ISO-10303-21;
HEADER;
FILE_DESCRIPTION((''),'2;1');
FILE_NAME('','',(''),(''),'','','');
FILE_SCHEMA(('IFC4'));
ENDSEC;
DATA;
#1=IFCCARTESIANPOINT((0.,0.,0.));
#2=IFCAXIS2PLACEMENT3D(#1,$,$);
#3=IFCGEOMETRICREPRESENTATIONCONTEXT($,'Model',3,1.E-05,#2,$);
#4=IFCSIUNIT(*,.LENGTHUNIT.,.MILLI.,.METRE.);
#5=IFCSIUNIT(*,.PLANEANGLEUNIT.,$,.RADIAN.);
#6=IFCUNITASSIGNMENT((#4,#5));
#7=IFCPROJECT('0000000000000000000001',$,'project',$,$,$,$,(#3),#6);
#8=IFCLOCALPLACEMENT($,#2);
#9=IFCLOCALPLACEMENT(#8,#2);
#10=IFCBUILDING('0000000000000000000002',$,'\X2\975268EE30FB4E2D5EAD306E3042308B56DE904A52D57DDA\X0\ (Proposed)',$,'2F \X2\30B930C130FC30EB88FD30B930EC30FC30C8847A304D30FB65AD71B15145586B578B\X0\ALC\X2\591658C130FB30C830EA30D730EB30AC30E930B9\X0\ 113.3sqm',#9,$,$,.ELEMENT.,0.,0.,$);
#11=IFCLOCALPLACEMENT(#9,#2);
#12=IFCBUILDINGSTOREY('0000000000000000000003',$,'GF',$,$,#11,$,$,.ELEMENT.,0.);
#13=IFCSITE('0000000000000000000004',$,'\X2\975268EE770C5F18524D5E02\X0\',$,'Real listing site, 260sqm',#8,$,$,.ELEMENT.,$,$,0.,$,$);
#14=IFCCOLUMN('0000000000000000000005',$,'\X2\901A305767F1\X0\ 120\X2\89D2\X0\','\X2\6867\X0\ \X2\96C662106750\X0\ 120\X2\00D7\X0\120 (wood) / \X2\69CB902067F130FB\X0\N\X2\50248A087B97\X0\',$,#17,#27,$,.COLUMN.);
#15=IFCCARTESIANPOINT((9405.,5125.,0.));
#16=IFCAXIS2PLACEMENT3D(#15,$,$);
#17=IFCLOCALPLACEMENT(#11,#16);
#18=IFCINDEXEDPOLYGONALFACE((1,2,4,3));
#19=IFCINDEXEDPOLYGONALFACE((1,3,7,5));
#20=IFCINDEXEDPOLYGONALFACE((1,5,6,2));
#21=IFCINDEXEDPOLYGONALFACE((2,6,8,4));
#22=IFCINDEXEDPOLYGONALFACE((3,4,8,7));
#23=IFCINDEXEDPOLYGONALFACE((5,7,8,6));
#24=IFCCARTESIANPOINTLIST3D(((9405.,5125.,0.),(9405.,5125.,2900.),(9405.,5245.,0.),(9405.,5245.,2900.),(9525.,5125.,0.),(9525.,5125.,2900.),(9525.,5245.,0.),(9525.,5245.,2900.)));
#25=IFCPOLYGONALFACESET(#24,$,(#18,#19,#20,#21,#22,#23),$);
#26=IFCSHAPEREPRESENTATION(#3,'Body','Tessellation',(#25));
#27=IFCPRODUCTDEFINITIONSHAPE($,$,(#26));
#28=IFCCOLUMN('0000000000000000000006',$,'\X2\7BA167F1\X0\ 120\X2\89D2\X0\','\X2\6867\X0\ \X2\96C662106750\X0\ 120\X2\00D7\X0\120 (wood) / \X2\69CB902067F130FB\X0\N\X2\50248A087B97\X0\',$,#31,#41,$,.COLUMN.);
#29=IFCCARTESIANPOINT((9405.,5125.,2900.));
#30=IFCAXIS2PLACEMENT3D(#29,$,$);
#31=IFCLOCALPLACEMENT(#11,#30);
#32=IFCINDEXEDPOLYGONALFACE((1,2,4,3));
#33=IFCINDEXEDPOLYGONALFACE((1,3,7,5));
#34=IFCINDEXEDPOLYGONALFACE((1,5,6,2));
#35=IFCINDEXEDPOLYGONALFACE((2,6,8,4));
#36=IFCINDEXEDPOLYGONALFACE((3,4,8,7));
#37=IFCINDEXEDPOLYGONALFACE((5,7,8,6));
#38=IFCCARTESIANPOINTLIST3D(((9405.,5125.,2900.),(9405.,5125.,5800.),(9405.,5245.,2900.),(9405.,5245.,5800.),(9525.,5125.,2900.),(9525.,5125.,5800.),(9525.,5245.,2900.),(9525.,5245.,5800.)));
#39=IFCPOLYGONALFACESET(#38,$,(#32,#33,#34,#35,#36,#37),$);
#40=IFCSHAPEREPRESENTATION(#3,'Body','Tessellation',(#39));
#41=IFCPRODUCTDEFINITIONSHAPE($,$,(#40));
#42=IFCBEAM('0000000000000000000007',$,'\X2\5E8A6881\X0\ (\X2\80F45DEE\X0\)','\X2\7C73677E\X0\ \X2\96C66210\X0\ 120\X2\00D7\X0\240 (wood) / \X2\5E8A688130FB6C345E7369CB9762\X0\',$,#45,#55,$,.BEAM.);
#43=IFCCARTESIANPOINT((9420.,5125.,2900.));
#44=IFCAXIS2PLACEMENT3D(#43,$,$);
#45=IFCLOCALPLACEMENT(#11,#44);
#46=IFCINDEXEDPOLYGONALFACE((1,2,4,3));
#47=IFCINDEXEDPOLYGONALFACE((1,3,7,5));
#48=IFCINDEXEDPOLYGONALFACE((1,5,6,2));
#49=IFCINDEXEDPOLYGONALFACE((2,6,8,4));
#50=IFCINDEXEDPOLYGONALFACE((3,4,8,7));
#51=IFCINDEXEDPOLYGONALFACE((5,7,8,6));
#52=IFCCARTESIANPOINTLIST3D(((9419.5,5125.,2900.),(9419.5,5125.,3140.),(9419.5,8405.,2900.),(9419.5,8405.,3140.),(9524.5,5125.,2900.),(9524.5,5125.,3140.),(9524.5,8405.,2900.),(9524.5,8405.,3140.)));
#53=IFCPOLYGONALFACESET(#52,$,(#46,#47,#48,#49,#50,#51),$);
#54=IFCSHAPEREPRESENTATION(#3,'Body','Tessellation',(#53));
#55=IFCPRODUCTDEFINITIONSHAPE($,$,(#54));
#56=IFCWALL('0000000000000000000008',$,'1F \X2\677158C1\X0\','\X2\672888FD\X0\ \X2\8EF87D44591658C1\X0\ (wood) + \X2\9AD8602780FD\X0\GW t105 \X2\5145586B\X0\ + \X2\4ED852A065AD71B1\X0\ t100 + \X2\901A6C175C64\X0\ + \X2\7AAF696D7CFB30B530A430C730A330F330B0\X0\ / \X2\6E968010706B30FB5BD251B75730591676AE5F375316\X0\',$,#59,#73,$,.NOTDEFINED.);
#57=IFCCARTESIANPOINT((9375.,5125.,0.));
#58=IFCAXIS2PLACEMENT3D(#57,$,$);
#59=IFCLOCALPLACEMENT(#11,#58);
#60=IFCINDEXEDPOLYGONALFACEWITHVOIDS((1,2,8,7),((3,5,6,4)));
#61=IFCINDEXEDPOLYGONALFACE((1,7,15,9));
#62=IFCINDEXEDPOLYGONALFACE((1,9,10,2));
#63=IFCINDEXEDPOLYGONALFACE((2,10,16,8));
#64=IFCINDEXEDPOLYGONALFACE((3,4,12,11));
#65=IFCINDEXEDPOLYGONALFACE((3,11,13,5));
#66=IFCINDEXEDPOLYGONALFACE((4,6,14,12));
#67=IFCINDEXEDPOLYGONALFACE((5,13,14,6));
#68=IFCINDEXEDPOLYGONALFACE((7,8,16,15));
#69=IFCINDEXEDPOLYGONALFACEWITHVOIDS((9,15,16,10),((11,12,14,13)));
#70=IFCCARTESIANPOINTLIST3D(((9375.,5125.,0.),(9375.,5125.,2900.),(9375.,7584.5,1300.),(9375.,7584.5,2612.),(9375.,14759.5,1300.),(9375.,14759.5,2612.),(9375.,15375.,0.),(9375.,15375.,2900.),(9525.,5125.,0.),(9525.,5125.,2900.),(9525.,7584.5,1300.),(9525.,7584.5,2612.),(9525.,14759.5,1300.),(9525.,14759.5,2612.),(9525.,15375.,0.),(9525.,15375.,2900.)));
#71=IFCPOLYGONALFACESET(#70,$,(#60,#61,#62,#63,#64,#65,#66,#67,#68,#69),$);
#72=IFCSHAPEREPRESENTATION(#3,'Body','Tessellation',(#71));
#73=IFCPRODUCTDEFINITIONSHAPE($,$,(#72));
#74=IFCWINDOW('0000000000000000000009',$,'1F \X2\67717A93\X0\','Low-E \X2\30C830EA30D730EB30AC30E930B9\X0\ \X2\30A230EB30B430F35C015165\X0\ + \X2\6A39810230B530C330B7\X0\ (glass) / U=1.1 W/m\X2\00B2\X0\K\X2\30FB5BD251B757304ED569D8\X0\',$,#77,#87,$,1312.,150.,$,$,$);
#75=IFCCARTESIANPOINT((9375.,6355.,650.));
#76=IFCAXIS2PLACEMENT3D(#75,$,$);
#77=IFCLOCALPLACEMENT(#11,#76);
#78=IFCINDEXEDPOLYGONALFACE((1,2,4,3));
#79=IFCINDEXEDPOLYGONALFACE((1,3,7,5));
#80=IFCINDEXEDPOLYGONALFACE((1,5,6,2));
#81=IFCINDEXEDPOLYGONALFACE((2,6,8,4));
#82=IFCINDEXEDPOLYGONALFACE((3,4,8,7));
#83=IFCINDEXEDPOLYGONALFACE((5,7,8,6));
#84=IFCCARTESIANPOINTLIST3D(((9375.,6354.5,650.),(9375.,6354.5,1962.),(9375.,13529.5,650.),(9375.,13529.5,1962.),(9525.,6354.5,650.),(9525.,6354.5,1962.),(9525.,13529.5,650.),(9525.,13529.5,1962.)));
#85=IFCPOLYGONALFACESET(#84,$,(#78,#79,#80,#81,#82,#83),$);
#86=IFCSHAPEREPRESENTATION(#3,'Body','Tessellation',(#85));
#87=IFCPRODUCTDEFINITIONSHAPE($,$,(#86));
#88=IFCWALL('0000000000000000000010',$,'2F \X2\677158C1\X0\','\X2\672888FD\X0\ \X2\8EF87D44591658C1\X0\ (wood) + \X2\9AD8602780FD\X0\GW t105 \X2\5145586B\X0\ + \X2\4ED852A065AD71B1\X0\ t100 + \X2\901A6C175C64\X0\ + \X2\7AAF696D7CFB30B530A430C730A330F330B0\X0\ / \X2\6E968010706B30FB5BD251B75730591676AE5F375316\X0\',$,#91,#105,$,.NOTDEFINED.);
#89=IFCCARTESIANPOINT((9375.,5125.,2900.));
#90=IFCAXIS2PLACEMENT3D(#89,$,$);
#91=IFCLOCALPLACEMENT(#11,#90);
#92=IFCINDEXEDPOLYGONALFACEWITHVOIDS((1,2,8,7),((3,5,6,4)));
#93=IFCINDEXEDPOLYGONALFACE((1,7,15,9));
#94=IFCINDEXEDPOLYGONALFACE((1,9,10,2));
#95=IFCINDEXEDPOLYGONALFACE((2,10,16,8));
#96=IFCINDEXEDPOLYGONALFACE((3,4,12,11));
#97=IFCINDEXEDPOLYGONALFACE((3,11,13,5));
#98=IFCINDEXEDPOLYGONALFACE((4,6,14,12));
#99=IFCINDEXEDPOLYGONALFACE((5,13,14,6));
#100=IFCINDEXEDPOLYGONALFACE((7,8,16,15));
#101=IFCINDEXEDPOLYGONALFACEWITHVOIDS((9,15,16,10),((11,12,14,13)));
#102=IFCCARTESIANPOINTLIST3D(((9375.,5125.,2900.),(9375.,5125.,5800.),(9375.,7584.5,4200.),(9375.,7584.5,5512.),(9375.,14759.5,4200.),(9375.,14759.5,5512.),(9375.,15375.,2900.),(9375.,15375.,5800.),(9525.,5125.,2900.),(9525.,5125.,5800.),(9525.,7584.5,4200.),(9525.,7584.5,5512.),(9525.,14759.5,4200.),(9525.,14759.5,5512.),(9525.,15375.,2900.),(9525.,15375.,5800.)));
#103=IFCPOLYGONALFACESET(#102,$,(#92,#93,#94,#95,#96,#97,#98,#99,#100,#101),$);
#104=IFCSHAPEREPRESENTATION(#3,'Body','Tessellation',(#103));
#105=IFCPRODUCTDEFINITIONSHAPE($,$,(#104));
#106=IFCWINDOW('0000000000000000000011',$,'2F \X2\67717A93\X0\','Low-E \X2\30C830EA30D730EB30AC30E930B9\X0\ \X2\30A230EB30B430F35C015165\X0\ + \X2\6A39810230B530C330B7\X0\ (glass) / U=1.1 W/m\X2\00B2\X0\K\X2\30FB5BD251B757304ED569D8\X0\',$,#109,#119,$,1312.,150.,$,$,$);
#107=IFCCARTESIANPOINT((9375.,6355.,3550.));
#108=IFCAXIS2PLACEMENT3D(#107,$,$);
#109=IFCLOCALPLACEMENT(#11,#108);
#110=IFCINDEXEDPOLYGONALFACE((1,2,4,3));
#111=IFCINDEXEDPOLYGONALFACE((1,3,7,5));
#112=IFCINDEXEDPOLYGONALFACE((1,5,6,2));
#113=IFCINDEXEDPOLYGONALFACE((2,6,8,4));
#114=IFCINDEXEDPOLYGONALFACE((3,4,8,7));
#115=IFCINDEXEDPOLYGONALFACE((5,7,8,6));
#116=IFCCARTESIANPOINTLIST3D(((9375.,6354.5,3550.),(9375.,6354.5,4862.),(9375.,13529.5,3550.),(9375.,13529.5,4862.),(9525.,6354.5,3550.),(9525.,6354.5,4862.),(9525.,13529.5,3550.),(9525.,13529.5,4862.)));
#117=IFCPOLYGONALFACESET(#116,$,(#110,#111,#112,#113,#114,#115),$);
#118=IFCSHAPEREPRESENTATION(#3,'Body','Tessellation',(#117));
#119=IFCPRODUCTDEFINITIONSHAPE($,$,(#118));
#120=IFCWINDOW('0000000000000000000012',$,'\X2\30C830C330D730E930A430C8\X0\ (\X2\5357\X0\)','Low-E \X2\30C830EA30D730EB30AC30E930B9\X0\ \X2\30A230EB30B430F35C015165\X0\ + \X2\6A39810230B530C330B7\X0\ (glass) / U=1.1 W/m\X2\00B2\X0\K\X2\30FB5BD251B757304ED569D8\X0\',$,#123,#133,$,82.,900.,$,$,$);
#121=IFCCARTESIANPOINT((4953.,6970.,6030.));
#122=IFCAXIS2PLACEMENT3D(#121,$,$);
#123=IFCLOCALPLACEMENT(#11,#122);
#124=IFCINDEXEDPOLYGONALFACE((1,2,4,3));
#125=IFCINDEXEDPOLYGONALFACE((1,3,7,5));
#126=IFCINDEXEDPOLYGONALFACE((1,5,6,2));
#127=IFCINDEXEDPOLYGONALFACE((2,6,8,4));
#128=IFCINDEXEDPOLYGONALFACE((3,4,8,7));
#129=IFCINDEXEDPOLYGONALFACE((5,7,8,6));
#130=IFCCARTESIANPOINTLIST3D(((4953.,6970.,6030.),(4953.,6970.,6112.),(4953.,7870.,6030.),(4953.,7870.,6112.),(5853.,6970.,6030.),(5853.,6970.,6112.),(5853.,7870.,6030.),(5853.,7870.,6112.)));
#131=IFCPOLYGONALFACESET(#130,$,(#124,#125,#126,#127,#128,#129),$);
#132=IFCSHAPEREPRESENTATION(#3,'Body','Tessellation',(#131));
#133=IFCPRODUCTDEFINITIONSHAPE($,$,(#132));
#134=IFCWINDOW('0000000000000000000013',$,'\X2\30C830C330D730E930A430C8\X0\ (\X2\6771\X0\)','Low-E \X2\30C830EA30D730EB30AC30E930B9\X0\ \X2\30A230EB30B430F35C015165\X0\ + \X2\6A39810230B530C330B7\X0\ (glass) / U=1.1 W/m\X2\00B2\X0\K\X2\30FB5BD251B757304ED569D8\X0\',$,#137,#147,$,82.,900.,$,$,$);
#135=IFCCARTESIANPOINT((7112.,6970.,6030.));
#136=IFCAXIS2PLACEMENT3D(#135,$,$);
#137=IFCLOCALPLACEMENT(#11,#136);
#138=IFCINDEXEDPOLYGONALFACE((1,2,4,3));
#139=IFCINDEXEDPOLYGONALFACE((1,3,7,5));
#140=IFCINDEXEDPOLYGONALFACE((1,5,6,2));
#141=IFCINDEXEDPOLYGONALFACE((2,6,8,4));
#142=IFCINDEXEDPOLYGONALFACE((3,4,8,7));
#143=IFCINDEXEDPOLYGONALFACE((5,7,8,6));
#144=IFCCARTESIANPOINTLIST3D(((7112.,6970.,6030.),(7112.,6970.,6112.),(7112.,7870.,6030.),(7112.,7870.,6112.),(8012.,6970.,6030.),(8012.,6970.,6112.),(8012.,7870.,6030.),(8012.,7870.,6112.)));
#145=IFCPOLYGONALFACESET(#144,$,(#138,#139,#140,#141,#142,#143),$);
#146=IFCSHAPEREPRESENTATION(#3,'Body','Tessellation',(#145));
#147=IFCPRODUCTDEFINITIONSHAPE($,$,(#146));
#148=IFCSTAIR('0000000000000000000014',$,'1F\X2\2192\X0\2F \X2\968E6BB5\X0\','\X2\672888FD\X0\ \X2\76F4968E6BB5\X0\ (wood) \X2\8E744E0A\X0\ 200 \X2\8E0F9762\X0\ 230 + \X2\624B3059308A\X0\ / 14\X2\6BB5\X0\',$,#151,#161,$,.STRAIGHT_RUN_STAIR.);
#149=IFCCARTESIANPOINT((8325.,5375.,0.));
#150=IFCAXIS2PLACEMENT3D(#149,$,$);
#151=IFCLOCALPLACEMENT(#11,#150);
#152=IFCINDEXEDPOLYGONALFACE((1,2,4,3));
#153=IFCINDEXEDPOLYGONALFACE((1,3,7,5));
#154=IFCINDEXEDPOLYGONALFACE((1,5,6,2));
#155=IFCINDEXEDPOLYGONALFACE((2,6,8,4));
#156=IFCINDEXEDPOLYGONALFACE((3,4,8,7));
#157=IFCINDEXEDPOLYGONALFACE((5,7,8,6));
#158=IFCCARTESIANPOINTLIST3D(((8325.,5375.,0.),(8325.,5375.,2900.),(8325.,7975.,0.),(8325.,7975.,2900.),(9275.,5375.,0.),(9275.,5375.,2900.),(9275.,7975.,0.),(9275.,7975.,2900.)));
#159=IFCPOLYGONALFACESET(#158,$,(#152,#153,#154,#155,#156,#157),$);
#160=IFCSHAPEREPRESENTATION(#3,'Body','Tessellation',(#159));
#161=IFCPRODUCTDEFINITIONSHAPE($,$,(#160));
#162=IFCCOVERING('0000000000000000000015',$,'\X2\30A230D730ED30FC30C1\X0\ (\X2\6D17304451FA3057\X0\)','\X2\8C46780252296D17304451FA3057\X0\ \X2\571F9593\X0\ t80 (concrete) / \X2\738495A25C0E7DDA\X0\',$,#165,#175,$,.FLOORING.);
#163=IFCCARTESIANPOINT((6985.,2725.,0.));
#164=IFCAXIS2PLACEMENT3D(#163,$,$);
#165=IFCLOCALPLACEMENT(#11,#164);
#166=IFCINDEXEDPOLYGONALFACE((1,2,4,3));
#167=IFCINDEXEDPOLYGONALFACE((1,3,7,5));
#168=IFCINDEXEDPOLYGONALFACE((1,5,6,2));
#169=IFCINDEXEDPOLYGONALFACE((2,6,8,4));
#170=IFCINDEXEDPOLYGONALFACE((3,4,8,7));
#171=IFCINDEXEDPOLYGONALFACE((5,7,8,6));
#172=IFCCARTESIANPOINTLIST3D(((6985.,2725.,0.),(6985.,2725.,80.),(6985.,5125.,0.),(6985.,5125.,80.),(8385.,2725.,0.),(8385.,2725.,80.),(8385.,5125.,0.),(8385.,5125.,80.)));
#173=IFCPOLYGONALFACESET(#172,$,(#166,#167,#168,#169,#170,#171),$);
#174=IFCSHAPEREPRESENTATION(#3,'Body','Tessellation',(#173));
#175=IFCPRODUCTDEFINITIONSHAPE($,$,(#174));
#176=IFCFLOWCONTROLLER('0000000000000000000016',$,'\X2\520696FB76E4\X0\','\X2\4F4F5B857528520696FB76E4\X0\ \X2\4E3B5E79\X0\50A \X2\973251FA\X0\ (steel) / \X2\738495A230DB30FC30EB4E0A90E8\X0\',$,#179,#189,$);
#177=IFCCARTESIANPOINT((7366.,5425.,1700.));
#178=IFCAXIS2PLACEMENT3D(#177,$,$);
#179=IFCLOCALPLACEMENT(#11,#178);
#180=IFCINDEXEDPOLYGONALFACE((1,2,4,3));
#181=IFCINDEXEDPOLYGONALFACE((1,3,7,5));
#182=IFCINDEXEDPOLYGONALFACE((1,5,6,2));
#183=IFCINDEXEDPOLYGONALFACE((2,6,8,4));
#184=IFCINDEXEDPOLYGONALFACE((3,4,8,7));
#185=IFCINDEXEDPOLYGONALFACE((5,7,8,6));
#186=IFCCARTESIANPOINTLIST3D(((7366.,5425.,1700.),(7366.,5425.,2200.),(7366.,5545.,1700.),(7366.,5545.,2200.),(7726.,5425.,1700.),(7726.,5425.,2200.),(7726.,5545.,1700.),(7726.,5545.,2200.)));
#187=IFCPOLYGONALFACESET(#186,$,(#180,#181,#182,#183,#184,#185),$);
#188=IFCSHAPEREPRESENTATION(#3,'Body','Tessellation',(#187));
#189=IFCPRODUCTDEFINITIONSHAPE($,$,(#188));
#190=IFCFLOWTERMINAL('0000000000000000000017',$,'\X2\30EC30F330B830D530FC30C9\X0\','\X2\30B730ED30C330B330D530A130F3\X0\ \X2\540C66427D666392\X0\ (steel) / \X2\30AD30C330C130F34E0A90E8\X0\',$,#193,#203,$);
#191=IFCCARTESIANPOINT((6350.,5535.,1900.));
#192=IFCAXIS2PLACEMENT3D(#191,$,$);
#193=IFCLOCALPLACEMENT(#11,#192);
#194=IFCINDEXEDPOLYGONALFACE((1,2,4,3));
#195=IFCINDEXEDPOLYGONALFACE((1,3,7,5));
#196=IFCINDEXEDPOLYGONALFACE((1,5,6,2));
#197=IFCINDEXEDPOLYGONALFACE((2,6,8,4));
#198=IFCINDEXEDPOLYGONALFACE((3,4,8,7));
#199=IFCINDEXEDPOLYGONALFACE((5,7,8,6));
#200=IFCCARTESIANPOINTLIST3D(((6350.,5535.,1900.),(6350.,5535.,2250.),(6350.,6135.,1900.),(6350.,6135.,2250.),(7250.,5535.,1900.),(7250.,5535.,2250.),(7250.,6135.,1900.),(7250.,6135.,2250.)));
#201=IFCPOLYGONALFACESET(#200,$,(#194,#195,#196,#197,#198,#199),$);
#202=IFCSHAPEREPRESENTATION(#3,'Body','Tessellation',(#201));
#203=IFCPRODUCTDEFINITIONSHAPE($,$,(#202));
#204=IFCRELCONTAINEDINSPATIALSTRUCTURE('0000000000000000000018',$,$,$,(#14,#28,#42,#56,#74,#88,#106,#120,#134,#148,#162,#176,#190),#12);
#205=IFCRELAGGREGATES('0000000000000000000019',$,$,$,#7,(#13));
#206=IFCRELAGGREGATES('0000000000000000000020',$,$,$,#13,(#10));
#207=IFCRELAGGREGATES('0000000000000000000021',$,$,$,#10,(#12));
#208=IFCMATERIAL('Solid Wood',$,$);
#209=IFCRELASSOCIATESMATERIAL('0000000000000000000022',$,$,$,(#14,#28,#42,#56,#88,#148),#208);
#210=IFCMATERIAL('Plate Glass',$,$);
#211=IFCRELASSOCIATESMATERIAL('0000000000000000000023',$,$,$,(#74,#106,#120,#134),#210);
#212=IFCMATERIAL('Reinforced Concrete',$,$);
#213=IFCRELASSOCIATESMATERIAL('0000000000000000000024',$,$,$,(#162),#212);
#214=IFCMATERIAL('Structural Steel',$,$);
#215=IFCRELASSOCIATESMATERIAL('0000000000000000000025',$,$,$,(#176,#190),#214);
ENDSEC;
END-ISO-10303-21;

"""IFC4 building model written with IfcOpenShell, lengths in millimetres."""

from ifc_helpers import new_model, si_unit, frame, frame_2d, origin, place, context, project, spatial, rectangle, extrude, material, element, fill, save


model = new_model("IFC4")

# Units and contexts
model_context = context("Model", 3, precision=1e-05, world=origin())
ifc_project = project(units=[si_unit("LENGTHUNIT", "METRE", prefix="MILLI"), si_unit("PLANEANGLEUNIT", "RADIAN")], contexts=[model_context])

# Site, building, storey
site_placement = place(None, origin())
site = spatial("IfcSite", under=ifc_project, at=site_placement, Name="青森県弘前市", ObjectType="Real listing site, 260sqm", CompositionType="ELEMENT", RefElevation=0.0)
building_placement = place(site_placement, origin())
building = spatial("IfcBuilding", under=site, at=building_placement, Name="青森・中庭のある回遊動線 (Proposed)", ObjectType="2F スチール製スレート葺き・断熱充填型ALC外壁・トリプルガラス 113.3sqm", CompositionType="ELEMENT", ElevationOfRefHeight=0.0, ElevationOfTerrain=0.0)
storey_placement = place(building_placement, origin())
storey = spatial("IfcBuildingStorey", under=building, at=storey_placement, Name="GF", CompositionType="ELEMENT", Elevation=0.0)

# Columns
ifc_material_1 = material(Name="Solid Wood")
column_1_placement = place(storey_placement, frame((9405.0, 5125.0, 0.0)))
element("IfcColumn", 1, at=column_1_placement, inside=storey, material=ifc_material_1, Name="通し柱 120角", Description="桧 集成材 120×120 (wood) / 構造柱・N値計算", PredefinedType="COLUMN", context=model_context, shape_type="SweptSolid", body=[
    extrude(rectangle(XDim=120.0, YDim=120.0, at=frame_2d((60.0, 60.0))), frame((9405.0, 5125.0, 0.0)), (0.0, 0.0, 1.0), 2900.0),
])
column_2_placement = place(storey_placement, frame((9405.0, 5125.0, 2900.0)))
element("IfcColumn", 2, at=column_2_placement, inside=storey, material=ifc_material_1, Name="管柱 120角", Description="桧 集成材 120×120 (wood) / 構造柱・N値計算", PredefinedType="COLUMN", context=model_context, shape_type="SweptSolid", body=[
    extrude(rectangle(XDim=120.0, YDim=120.0, at=frame_2d((60.0, 60.0))), frame((9405.0, 5125.0, 2900.0)), (0.0, 0.0, 1.0), 2900.0),
])

# Beam
beam_1_placement = place(storey_placement, frame((9420.0, 5125.0, 2900.0)))
element("IfcBeam", 3, at=beam_1_placement, inside=storey, material=ifc_material_1, Name="床梁 (胴差)", Description="米松 集成 120×240 (wood) / 床梁・水平構面", PredefinedType="BEAM", context=model_context, shape_type="SweptSolid", body=[
    extrude(rectangle(XDim=105.0, YDim=3280.0, at=frame_2d((52.0, 1640.0))), frame((9420.0, 5125.0, 2900.0)), (0.0, 0.0, 1.0), 240.0),
])

# Wall, opening, window
wall_1_placement = place(storey_placement, frame((9375.0, 5125.0, 0.0)))
wall_1 = element("IfcWall", 4, at=wall_1_placement, inside=storey, material=ifc_material_1, Name="1F 東壁", Description="木製 軸組外壁 (wood) + 高性能GW t105 充填 + 付加断熱 t100 + 通気層 + 窯業系サイディング / 準耐火・寒冷地外皮強化", PredefinedType="NOTDEFINED", context=model_context, shape_type="SweptSolid", body=[
    extrude(rectangle(XDim=150.0, YDim=10250.0, at=frame_2d((75.0, 5125.0))), frame((9375.0, 5125.0, 0.0)), (0.0, 0.0, 1.0), 2900.0),
])
opening_1_placement = place(storey_placement, frame((9375.0, 6355.0, 650.0)))
opening_1 = element("IfcOpeningElement", 5, at=opening_1_placement, cuts=wall_1, PredefinedType="NOTDEFINED", context=model_context, shape_type="SweptSolid", body=[
    extrude(rectangle(XDim=150.0, YDim=7175.0, at=frame_2d((75.0, 3587.0))), frame((9375.0, 6355.0, 650.0)), (0.0, 0.0, 1.0), 1312.0),
])
ifc_material_2 = material(Name="Plate Glass")
window_1_placement = place(storey_placement, frame((9375.0, 6355.0, 650.0)))
window_1 = element("IfcWindow", 6, at=window_1_placement, inside=storey, material=ifc_material_2, Name="1F 東窓", Description="Low-E トリプルガラス アルゴン封入 + 樹脂サッシ (glass) / U=1.1 W/m²K・寒冷地仕様", OverallHeight=1312.0, OverallWidth=150.0, context=model_context, shape_type="SweptSolid", body=[
    extrude(rectangle(XDim=150.0, YDim=7175.0, at=frame_2d((75.0, 3587.0))), frame((9375.0, 6355.0, 650.0)), (0.0, 0.0, 1.0), 1312.0),
])
fill(opening_1, window_1)

# Wall, opening, window
wall_2_placement = place(storey_placement, frame((9375.0, 5125.0, 2900.0)))
wall_2 = element("IfcWall", 7, at=wall_2_placement, inside=storey, material=ifc_material_1, Name="2F 東壁", Description="木製 軸組外壁 (wood) + 高性能GW t105 充填 + 付加断熱 t100 + 通気層 + 窯業系サイディング / 準耐火・寒冷地外皮強化", PredefinedType="NOTDEFINED", context=model_context, shape_type="SweptSolid", body=[
    extrude(rectangle(XDim=150.0, YDim=10250.0, at=frame_2d((75.0, 5125.0))), frame((9375.0, 5125.0, 2900.0)), (0.0, 0.0, 1.0), 2900.0),
])
opening_2_placement = place(storey_placement, frame((9375.0, 6355.0, 3550.0)))
opening_2 = element("IfcOpeningElement", 8, at=opening_2_placement, cuts=wall_2, PredefinedType="NOTDEFINED", context=model_context, shape_type="SweptSolid", body=[
    extrude(rectangle(XDim=150.0, YDim=7175.0, at=frame_2d((75.0, 3587.0))), frame((9375.0, 6355.0, 3550.0)), (0.0, 0.0, 1.0), 1312.0),
])
window_2_placement = place(storey_placement, frame((9375.0, 6355.0, 3550.0)))
window_2 = element("IfcWindow", 9, at=window_2_placement, inside=storey, material=ifc_material_2, Name="2F 東窓", Description="Low-E トリプルガラス アルゴン封入 + 樹脂サッシ (glass) / U=1.1 W/m²K・寒冷地仕様", OverallHeight=1312.0, OverallWidth=150.0, context=model_context, shape_type="SweptSolid", body=[
    extrude(rectangle(XDim=150.0, YDim=7175.0, at=frame_2d((75.0, 3587.0))), frame((9375.0, 6355.0, 3550.0)), (0.0, 0.0, 1.0), 1312.0),
])
fill(opening_2, window_2)

# Windows
window_3_placement = place(storey_placement, frame((4953.0, 6970.0, 6030.0)))
element("IfcWindow", 10, at=window_3_placement, inside=storey, material=ifc_material_2, Name="トップライト (南)", Description="Low-E トリプルガラス アルゴン封入 + 樹脂サッシ (glass) / U=1.1 W/m²K・寒冷地仕様", OverallHeight=82.0, OverallWidth=900.0, context=model_context, shape_type="SweptSolid", body=[
    extrude(rectangle(XDim=900.0, YDim=900.0, at=frame_2d((450.0, 450.0))), frame((4953.0, 6970.0, 6030.0)), (0.0, 0.0, 1.0), 82.0),
])
window_4_placement = place(storey_placement, frame((7112.0, 6970.0, 6030.0)))
element("IfcWindow", 11, at=window_4_placement, inside=storey, material=ifc_material_2, Name="トップライト (東)", Description="Low-E トリプルガラス アルゴン封入 + 樹脂サッシ (glass) / U=1.1 W/m²K・寒冷地仕様", OverallHeight=82.0, OverallWidth=900.0, context=model_context, shape_type="SweptSolid", body=[
    extrude(rectangle(XDim=900.0, YDim=900.0, at=frame_2d((450.0, 450.0))), frame((7112.0, 6970.0, 6030.0)), (0.0, 0.0, 1.0), 82.0),
])

# Stair
stair_placement = place(storey_placement, frame((8325.0, 5375.0, 0.0)))
element("IfcStair", 12, at=stair_placement, inside=storey, material=ifc_material_1, Name="1F→2F 階段", Description="木製 直階段 (wood) 蹴上 200 踏面 230 + 手すり / 14段", PredefinedType="STRAIGHT_RUN_STAIR", context=model_context, shape_type="SweptSolid", body=[
    extrude(rectangle(XDim=950.0, YDim=2600.0, at=frame_2d((475.0, 1300.0))), frame((8325.0, 5375.0, 0.0)), (0.0, 0.0, 1.0), 2900.0),
])

# Covering
ifc_material_3 = material(Name="Reinforced Concrete")
covering_placement = place(storey_placement, frame((6985.0, 2725.0, 0.0)))
element("IfcCovering", 13, at=covering_placement, inside=storey, material=ifc_material_3, Name="アプローチ (洗い出し)", Description="豆砂利洗い出し 土間 t80 (concrete) / 玄関導線", PredefinedType="FLOORING", context=model_context, shape_type="SweptSolid", body=[
    extrude(rectangle(XDim=1400.0, YDim=2400.0, at=frame_2d((700.0, 1200.0))), frame((6985.0, 2725.0, 0.0)), (0.0, 0.0, 1.0), 80.0),
])

# Flow controller
ifc_material_4 = material(Name="Structural Steel")
flow_controller_placement = place(storey_placement, frame((7366.0, 5425.0, 1700.0)))
element("IfcFlowController", 14, at=flow_controller_placement, inside=storey, material=ifc_material_4, Name="分電盤", Description="住宅用分電盤 主幹50A 露出 (steel) / 玄関ホール上部", context=model_context, shape_type="SweptSolid", body=[
    extrude(rectangle(XDim=360.0, YDim=120.0, at=frame_2d((180.0, 60.0))), frame((7366.0, 5425.0, 1700.0)), (0.0, 0.0, 1.0), 500.0),
])

# Flow terminal
flow_terminal_1_placement = place(storey_placement, frame((6350.0, 5535.0, 1900.0)))
element("IfcFlowTerminal", 15, at=flow_terminal_1_placement, inside=storey, material=ifc_material_4, Name="レンジフード", Description="シロッコファン 同時給排 (steel) / キッチン上部", context=model_context, shape_type="SweptSolid", body=[
    extrude(rectangle(XDim=900.0, YDim=600.0, at=frame_2d((450.0, 300.0))), frame((6350.0, 5535.0, 1900.0)), (0.0, 0.0, 1.0), 350.0),
])

save(model, "model.ifc")
